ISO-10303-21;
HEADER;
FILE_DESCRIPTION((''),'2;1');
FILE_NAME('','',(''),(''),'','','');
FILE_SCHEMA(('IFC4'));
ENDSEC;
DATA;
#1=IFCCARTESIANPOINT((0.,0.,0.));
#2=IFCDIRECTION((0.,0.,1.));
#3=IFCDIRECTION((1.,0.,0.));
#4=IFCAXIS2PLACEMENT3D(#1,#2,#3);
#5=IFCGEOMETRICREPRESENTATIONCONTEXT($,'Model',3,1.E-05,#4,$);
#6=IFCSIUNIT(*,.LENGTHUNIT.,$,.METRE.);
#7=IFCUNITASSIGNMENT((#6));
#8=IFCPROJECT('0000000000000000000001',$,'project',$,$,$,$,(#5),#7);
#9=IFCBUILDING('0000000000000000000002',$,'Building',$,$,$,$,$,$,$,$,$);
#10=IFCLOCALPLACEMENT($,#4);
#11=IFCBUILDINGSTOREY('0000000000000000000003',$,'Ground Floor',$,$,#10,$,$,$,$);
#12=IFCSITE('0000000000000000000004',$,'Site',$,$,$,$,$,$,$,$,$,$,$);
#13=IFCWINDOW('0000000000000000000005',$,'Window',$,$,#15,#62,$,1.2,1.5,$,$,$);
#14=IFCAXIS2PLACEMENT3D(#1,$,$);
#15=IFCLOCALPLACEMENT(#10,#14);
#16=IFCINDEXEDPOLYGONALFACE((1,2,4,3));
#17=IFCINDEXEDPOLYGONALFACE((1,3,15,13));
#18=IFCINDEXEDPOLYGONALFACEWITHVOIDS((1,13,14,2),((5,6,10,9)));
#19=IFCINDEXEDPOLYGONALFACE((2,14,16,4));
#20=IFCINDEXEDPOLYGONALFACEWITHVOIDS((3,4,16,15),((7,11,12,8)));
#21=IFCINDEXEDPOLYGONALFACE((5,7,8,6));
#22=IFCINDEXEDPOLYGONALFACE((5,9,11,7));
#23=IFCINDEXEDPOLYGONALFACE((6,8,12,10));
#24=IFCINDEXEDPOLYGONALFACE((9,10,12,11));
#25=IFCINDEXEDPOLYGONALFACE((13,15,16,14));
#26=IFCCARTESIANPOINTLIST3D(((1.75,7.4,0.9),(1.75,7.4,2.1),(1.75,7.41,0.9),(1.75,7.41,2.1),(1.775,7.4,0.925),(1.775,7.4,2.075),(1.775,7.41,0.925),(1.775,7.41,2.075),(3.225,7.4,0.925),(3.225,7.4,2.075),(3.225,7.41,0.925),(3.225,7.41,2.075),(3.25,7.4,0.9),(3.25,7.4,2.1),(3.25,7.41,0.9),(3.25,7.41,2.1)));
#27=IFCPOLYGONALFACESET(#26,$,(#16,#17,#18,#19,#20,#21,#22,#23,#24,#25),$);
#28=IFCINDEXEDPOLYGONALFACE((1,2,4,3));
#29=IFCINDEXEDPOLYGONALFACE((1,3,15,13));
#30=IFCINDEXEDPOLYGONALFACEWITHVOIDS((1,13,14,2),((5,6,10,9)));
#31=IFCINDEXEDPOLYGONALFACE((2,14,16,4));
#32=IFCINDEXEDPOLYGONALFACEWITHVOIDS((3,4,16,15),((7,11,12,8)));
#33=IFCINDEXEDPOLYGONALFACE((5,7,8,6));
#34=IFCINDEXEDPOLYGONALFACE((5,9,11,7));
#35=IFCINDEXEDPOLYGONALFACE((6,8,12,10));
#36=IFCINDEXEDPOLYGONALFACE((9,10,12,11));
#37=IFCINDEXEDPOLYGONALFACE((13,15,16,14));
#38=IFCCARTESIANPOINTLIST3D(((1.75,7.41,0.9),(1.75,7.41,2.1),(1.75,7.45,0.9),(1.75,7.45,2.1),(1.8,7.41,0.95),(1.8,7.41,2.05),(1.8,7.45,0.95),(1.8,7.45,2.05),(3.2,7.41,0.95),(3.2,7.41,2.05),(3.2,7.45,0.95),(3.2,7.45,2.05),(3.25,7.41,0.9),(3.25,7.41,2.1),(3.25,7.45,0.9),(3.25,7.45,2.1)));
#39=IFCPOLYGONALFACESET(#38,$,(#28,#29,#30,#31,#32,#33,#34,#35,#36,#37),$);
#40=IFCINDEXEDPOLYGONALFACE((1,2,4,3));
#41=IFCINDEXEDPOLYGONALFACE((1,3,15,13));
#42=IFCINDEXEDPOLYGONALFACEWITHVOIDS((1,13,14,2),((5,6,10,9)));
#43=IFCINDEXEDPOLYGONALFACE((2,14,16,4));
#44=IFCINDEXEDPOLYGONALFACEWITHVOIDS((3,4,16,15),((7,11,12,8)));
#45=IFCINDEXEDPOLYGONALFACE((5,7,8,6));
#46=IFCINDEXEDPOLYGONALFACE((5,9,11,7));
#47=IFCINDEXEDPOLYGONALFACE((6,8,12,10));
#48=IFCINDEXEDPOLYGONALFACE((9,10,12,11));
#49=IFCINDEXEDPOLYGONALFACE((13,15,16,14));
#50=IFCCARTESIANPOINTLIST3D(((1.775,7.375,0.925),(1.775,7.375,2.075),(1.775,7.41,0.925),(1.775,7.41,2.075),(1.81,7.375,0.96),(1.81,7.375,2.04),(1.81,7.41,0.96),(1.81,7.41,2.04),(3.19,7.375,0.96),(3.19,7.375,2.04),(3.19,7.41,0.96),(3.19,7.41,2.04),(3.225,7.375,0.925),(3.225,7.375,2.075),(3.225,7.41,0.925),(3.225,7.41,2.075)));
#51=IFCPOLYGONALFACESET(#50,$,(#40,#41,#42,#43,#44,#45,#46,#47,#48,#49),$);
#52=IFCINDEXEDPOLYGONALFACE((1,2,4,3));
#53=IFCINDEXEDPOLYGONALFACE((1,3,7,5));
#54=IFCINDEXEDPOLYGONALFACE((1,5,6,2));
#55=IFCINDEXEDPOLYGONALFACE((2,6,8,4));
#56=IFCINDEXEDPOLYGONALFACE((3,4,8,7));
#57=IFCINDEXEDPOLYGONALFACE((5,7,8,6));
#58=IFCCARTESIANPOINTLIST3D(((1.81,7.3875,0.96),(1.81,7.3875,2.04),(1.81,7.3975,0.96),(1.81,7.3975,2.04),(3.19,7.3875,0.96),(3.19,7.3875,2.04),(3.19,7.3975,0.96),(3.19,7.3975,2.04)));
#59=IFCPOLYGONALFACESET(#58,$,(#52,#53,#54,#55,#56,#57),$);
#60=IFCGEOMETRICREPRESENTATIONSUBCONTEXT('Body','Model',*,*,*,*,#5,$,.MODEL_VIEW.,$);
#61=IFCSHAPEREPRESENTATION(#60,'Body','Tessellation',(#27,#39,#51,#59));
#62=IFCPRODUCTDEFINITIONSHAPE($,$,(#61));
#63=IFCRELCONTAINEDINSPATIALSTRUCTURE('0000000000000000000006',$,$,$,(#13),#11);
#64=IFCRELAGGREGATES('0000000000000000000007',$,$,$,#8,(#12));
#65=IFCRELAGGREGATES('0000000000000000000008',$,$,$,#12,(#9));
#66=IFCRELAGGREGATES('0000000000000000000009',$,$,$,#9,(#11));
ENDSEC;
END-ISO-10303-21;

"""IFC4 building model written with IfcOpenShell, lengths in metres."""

from ifc_helpers import new_model, si_unit, frame, origin_with_axes, place, context, subcontext, project, spatial, line, indexed_curve, outline, extrude, element, save


model = new_model("IFC4")

# Units and contexts
model_context = context("Model", 3, precision=1e-05, world=origin_with_axes())
body_context = subcontext(model_context, "Body", "Model", "MODEL_VIEW")
ifc_project = project(units=[si_unit("LENGTHUNIT", "METRE")], contexts=[model_context])

# Site, building, storey
site = spatial("IfcSite", under=ifc_project, Name="Site")
building = spatial("IfcBuilding", under=site, Name="Building")
storey_placement = place(None, origin_with_axes())
storey = spatial("IfcBuildingStorey", under=building, at=storey_placement, Name="Ground Floor")

# Window
for number, where, z_axis, x_axis, name in (
    (1, (3.25, 7.5, 0.9), (0.0, 0.0, 1.0), (-1.0, 0.0, 0.0), "Window"),
):
    element("IfcWindow", number, at=place(storey_placement, frame(where, z_axis=z_axis, x_axis=x_axis)), inside=storey, Name=name, OverallHeight=1.2, OverallWidth=1.5, context=body_context, shape_type="SweptSolid", body=[
        extrude(outline(indexed_curve([(0.0, 0.0), (1.5, 0.0), (1.5, 1.2), (0.0, 1.2)], segments=[line(1, 2, 3, 4, 1)]), holes=[indexed_curve([(0.025, 0.025), (1.475, 0.025), (1.475, 1.175), (0.025, 1.175)], segments=[line(1, 2, 3, 4, 1)])]), frame((0.0, 0.09, 0.0), z_axis=(0.0, -1.0, 0.0), x_axis=(1.0, 0.0, 0.0)), (0.0, 0.0, -1.0), 0.01),
        extrude(outline(indexed_curve([(0.0, 0.0), (1.5, 0.0), (1.5, 1.2), (0.0, 1.2)], segments=[line(1, 2, 3, 4, 1)]), holes=[indexed_curve([(0.05, 0.05), (1.45, 0.05), (1.45, 1.15), (0.05, 1.15)], segments=[line(1, 2, 3, 4, 1)])]), frame((0.0, 0.05, 0.0), z_axis=(0.0, -1.0, 0.0), x_axis=(1.0, 0.0, 0.0)), (0.0, 0.0, -1.0), 0.04),
        extrude(outline(indexed_curve([(0.0, 0.0), (1.45, 0.0), (1.45, 1.15), (0.0, 1.15)], segments=[line(1, 2, 3, 4, 1)]), holes=[indexed_curve([(0.035, 0.035), (1.415, 0.035), (1.415, 1.115), (0.035, 1.115)], segments=[line(1, 2, 3, 4, 1)])]), frame((0.025, 0.09, 0.025), z_axis=(0.0, -1.0, 0.0), x_axis=(1.0, 0.0, 0.0)), (0.0, 0.0, -1.0), 0.035),
        extrude(outline(indexed_curve([(0.035, 0.035), (1.415, 0.035), (1.415, 1.115), (0.035, 1.115)], segments=[line(1, 2, 3, 4, 1)])), frame((0.025, 0.1025, 0.025), z_axis=(0.0, -1.0, 0.0), x_axis=(1.0, 0.0, 0.0)), (0.0, 0.0, -1.0), 0.01),
    ])

save(model, "model.ifc")
